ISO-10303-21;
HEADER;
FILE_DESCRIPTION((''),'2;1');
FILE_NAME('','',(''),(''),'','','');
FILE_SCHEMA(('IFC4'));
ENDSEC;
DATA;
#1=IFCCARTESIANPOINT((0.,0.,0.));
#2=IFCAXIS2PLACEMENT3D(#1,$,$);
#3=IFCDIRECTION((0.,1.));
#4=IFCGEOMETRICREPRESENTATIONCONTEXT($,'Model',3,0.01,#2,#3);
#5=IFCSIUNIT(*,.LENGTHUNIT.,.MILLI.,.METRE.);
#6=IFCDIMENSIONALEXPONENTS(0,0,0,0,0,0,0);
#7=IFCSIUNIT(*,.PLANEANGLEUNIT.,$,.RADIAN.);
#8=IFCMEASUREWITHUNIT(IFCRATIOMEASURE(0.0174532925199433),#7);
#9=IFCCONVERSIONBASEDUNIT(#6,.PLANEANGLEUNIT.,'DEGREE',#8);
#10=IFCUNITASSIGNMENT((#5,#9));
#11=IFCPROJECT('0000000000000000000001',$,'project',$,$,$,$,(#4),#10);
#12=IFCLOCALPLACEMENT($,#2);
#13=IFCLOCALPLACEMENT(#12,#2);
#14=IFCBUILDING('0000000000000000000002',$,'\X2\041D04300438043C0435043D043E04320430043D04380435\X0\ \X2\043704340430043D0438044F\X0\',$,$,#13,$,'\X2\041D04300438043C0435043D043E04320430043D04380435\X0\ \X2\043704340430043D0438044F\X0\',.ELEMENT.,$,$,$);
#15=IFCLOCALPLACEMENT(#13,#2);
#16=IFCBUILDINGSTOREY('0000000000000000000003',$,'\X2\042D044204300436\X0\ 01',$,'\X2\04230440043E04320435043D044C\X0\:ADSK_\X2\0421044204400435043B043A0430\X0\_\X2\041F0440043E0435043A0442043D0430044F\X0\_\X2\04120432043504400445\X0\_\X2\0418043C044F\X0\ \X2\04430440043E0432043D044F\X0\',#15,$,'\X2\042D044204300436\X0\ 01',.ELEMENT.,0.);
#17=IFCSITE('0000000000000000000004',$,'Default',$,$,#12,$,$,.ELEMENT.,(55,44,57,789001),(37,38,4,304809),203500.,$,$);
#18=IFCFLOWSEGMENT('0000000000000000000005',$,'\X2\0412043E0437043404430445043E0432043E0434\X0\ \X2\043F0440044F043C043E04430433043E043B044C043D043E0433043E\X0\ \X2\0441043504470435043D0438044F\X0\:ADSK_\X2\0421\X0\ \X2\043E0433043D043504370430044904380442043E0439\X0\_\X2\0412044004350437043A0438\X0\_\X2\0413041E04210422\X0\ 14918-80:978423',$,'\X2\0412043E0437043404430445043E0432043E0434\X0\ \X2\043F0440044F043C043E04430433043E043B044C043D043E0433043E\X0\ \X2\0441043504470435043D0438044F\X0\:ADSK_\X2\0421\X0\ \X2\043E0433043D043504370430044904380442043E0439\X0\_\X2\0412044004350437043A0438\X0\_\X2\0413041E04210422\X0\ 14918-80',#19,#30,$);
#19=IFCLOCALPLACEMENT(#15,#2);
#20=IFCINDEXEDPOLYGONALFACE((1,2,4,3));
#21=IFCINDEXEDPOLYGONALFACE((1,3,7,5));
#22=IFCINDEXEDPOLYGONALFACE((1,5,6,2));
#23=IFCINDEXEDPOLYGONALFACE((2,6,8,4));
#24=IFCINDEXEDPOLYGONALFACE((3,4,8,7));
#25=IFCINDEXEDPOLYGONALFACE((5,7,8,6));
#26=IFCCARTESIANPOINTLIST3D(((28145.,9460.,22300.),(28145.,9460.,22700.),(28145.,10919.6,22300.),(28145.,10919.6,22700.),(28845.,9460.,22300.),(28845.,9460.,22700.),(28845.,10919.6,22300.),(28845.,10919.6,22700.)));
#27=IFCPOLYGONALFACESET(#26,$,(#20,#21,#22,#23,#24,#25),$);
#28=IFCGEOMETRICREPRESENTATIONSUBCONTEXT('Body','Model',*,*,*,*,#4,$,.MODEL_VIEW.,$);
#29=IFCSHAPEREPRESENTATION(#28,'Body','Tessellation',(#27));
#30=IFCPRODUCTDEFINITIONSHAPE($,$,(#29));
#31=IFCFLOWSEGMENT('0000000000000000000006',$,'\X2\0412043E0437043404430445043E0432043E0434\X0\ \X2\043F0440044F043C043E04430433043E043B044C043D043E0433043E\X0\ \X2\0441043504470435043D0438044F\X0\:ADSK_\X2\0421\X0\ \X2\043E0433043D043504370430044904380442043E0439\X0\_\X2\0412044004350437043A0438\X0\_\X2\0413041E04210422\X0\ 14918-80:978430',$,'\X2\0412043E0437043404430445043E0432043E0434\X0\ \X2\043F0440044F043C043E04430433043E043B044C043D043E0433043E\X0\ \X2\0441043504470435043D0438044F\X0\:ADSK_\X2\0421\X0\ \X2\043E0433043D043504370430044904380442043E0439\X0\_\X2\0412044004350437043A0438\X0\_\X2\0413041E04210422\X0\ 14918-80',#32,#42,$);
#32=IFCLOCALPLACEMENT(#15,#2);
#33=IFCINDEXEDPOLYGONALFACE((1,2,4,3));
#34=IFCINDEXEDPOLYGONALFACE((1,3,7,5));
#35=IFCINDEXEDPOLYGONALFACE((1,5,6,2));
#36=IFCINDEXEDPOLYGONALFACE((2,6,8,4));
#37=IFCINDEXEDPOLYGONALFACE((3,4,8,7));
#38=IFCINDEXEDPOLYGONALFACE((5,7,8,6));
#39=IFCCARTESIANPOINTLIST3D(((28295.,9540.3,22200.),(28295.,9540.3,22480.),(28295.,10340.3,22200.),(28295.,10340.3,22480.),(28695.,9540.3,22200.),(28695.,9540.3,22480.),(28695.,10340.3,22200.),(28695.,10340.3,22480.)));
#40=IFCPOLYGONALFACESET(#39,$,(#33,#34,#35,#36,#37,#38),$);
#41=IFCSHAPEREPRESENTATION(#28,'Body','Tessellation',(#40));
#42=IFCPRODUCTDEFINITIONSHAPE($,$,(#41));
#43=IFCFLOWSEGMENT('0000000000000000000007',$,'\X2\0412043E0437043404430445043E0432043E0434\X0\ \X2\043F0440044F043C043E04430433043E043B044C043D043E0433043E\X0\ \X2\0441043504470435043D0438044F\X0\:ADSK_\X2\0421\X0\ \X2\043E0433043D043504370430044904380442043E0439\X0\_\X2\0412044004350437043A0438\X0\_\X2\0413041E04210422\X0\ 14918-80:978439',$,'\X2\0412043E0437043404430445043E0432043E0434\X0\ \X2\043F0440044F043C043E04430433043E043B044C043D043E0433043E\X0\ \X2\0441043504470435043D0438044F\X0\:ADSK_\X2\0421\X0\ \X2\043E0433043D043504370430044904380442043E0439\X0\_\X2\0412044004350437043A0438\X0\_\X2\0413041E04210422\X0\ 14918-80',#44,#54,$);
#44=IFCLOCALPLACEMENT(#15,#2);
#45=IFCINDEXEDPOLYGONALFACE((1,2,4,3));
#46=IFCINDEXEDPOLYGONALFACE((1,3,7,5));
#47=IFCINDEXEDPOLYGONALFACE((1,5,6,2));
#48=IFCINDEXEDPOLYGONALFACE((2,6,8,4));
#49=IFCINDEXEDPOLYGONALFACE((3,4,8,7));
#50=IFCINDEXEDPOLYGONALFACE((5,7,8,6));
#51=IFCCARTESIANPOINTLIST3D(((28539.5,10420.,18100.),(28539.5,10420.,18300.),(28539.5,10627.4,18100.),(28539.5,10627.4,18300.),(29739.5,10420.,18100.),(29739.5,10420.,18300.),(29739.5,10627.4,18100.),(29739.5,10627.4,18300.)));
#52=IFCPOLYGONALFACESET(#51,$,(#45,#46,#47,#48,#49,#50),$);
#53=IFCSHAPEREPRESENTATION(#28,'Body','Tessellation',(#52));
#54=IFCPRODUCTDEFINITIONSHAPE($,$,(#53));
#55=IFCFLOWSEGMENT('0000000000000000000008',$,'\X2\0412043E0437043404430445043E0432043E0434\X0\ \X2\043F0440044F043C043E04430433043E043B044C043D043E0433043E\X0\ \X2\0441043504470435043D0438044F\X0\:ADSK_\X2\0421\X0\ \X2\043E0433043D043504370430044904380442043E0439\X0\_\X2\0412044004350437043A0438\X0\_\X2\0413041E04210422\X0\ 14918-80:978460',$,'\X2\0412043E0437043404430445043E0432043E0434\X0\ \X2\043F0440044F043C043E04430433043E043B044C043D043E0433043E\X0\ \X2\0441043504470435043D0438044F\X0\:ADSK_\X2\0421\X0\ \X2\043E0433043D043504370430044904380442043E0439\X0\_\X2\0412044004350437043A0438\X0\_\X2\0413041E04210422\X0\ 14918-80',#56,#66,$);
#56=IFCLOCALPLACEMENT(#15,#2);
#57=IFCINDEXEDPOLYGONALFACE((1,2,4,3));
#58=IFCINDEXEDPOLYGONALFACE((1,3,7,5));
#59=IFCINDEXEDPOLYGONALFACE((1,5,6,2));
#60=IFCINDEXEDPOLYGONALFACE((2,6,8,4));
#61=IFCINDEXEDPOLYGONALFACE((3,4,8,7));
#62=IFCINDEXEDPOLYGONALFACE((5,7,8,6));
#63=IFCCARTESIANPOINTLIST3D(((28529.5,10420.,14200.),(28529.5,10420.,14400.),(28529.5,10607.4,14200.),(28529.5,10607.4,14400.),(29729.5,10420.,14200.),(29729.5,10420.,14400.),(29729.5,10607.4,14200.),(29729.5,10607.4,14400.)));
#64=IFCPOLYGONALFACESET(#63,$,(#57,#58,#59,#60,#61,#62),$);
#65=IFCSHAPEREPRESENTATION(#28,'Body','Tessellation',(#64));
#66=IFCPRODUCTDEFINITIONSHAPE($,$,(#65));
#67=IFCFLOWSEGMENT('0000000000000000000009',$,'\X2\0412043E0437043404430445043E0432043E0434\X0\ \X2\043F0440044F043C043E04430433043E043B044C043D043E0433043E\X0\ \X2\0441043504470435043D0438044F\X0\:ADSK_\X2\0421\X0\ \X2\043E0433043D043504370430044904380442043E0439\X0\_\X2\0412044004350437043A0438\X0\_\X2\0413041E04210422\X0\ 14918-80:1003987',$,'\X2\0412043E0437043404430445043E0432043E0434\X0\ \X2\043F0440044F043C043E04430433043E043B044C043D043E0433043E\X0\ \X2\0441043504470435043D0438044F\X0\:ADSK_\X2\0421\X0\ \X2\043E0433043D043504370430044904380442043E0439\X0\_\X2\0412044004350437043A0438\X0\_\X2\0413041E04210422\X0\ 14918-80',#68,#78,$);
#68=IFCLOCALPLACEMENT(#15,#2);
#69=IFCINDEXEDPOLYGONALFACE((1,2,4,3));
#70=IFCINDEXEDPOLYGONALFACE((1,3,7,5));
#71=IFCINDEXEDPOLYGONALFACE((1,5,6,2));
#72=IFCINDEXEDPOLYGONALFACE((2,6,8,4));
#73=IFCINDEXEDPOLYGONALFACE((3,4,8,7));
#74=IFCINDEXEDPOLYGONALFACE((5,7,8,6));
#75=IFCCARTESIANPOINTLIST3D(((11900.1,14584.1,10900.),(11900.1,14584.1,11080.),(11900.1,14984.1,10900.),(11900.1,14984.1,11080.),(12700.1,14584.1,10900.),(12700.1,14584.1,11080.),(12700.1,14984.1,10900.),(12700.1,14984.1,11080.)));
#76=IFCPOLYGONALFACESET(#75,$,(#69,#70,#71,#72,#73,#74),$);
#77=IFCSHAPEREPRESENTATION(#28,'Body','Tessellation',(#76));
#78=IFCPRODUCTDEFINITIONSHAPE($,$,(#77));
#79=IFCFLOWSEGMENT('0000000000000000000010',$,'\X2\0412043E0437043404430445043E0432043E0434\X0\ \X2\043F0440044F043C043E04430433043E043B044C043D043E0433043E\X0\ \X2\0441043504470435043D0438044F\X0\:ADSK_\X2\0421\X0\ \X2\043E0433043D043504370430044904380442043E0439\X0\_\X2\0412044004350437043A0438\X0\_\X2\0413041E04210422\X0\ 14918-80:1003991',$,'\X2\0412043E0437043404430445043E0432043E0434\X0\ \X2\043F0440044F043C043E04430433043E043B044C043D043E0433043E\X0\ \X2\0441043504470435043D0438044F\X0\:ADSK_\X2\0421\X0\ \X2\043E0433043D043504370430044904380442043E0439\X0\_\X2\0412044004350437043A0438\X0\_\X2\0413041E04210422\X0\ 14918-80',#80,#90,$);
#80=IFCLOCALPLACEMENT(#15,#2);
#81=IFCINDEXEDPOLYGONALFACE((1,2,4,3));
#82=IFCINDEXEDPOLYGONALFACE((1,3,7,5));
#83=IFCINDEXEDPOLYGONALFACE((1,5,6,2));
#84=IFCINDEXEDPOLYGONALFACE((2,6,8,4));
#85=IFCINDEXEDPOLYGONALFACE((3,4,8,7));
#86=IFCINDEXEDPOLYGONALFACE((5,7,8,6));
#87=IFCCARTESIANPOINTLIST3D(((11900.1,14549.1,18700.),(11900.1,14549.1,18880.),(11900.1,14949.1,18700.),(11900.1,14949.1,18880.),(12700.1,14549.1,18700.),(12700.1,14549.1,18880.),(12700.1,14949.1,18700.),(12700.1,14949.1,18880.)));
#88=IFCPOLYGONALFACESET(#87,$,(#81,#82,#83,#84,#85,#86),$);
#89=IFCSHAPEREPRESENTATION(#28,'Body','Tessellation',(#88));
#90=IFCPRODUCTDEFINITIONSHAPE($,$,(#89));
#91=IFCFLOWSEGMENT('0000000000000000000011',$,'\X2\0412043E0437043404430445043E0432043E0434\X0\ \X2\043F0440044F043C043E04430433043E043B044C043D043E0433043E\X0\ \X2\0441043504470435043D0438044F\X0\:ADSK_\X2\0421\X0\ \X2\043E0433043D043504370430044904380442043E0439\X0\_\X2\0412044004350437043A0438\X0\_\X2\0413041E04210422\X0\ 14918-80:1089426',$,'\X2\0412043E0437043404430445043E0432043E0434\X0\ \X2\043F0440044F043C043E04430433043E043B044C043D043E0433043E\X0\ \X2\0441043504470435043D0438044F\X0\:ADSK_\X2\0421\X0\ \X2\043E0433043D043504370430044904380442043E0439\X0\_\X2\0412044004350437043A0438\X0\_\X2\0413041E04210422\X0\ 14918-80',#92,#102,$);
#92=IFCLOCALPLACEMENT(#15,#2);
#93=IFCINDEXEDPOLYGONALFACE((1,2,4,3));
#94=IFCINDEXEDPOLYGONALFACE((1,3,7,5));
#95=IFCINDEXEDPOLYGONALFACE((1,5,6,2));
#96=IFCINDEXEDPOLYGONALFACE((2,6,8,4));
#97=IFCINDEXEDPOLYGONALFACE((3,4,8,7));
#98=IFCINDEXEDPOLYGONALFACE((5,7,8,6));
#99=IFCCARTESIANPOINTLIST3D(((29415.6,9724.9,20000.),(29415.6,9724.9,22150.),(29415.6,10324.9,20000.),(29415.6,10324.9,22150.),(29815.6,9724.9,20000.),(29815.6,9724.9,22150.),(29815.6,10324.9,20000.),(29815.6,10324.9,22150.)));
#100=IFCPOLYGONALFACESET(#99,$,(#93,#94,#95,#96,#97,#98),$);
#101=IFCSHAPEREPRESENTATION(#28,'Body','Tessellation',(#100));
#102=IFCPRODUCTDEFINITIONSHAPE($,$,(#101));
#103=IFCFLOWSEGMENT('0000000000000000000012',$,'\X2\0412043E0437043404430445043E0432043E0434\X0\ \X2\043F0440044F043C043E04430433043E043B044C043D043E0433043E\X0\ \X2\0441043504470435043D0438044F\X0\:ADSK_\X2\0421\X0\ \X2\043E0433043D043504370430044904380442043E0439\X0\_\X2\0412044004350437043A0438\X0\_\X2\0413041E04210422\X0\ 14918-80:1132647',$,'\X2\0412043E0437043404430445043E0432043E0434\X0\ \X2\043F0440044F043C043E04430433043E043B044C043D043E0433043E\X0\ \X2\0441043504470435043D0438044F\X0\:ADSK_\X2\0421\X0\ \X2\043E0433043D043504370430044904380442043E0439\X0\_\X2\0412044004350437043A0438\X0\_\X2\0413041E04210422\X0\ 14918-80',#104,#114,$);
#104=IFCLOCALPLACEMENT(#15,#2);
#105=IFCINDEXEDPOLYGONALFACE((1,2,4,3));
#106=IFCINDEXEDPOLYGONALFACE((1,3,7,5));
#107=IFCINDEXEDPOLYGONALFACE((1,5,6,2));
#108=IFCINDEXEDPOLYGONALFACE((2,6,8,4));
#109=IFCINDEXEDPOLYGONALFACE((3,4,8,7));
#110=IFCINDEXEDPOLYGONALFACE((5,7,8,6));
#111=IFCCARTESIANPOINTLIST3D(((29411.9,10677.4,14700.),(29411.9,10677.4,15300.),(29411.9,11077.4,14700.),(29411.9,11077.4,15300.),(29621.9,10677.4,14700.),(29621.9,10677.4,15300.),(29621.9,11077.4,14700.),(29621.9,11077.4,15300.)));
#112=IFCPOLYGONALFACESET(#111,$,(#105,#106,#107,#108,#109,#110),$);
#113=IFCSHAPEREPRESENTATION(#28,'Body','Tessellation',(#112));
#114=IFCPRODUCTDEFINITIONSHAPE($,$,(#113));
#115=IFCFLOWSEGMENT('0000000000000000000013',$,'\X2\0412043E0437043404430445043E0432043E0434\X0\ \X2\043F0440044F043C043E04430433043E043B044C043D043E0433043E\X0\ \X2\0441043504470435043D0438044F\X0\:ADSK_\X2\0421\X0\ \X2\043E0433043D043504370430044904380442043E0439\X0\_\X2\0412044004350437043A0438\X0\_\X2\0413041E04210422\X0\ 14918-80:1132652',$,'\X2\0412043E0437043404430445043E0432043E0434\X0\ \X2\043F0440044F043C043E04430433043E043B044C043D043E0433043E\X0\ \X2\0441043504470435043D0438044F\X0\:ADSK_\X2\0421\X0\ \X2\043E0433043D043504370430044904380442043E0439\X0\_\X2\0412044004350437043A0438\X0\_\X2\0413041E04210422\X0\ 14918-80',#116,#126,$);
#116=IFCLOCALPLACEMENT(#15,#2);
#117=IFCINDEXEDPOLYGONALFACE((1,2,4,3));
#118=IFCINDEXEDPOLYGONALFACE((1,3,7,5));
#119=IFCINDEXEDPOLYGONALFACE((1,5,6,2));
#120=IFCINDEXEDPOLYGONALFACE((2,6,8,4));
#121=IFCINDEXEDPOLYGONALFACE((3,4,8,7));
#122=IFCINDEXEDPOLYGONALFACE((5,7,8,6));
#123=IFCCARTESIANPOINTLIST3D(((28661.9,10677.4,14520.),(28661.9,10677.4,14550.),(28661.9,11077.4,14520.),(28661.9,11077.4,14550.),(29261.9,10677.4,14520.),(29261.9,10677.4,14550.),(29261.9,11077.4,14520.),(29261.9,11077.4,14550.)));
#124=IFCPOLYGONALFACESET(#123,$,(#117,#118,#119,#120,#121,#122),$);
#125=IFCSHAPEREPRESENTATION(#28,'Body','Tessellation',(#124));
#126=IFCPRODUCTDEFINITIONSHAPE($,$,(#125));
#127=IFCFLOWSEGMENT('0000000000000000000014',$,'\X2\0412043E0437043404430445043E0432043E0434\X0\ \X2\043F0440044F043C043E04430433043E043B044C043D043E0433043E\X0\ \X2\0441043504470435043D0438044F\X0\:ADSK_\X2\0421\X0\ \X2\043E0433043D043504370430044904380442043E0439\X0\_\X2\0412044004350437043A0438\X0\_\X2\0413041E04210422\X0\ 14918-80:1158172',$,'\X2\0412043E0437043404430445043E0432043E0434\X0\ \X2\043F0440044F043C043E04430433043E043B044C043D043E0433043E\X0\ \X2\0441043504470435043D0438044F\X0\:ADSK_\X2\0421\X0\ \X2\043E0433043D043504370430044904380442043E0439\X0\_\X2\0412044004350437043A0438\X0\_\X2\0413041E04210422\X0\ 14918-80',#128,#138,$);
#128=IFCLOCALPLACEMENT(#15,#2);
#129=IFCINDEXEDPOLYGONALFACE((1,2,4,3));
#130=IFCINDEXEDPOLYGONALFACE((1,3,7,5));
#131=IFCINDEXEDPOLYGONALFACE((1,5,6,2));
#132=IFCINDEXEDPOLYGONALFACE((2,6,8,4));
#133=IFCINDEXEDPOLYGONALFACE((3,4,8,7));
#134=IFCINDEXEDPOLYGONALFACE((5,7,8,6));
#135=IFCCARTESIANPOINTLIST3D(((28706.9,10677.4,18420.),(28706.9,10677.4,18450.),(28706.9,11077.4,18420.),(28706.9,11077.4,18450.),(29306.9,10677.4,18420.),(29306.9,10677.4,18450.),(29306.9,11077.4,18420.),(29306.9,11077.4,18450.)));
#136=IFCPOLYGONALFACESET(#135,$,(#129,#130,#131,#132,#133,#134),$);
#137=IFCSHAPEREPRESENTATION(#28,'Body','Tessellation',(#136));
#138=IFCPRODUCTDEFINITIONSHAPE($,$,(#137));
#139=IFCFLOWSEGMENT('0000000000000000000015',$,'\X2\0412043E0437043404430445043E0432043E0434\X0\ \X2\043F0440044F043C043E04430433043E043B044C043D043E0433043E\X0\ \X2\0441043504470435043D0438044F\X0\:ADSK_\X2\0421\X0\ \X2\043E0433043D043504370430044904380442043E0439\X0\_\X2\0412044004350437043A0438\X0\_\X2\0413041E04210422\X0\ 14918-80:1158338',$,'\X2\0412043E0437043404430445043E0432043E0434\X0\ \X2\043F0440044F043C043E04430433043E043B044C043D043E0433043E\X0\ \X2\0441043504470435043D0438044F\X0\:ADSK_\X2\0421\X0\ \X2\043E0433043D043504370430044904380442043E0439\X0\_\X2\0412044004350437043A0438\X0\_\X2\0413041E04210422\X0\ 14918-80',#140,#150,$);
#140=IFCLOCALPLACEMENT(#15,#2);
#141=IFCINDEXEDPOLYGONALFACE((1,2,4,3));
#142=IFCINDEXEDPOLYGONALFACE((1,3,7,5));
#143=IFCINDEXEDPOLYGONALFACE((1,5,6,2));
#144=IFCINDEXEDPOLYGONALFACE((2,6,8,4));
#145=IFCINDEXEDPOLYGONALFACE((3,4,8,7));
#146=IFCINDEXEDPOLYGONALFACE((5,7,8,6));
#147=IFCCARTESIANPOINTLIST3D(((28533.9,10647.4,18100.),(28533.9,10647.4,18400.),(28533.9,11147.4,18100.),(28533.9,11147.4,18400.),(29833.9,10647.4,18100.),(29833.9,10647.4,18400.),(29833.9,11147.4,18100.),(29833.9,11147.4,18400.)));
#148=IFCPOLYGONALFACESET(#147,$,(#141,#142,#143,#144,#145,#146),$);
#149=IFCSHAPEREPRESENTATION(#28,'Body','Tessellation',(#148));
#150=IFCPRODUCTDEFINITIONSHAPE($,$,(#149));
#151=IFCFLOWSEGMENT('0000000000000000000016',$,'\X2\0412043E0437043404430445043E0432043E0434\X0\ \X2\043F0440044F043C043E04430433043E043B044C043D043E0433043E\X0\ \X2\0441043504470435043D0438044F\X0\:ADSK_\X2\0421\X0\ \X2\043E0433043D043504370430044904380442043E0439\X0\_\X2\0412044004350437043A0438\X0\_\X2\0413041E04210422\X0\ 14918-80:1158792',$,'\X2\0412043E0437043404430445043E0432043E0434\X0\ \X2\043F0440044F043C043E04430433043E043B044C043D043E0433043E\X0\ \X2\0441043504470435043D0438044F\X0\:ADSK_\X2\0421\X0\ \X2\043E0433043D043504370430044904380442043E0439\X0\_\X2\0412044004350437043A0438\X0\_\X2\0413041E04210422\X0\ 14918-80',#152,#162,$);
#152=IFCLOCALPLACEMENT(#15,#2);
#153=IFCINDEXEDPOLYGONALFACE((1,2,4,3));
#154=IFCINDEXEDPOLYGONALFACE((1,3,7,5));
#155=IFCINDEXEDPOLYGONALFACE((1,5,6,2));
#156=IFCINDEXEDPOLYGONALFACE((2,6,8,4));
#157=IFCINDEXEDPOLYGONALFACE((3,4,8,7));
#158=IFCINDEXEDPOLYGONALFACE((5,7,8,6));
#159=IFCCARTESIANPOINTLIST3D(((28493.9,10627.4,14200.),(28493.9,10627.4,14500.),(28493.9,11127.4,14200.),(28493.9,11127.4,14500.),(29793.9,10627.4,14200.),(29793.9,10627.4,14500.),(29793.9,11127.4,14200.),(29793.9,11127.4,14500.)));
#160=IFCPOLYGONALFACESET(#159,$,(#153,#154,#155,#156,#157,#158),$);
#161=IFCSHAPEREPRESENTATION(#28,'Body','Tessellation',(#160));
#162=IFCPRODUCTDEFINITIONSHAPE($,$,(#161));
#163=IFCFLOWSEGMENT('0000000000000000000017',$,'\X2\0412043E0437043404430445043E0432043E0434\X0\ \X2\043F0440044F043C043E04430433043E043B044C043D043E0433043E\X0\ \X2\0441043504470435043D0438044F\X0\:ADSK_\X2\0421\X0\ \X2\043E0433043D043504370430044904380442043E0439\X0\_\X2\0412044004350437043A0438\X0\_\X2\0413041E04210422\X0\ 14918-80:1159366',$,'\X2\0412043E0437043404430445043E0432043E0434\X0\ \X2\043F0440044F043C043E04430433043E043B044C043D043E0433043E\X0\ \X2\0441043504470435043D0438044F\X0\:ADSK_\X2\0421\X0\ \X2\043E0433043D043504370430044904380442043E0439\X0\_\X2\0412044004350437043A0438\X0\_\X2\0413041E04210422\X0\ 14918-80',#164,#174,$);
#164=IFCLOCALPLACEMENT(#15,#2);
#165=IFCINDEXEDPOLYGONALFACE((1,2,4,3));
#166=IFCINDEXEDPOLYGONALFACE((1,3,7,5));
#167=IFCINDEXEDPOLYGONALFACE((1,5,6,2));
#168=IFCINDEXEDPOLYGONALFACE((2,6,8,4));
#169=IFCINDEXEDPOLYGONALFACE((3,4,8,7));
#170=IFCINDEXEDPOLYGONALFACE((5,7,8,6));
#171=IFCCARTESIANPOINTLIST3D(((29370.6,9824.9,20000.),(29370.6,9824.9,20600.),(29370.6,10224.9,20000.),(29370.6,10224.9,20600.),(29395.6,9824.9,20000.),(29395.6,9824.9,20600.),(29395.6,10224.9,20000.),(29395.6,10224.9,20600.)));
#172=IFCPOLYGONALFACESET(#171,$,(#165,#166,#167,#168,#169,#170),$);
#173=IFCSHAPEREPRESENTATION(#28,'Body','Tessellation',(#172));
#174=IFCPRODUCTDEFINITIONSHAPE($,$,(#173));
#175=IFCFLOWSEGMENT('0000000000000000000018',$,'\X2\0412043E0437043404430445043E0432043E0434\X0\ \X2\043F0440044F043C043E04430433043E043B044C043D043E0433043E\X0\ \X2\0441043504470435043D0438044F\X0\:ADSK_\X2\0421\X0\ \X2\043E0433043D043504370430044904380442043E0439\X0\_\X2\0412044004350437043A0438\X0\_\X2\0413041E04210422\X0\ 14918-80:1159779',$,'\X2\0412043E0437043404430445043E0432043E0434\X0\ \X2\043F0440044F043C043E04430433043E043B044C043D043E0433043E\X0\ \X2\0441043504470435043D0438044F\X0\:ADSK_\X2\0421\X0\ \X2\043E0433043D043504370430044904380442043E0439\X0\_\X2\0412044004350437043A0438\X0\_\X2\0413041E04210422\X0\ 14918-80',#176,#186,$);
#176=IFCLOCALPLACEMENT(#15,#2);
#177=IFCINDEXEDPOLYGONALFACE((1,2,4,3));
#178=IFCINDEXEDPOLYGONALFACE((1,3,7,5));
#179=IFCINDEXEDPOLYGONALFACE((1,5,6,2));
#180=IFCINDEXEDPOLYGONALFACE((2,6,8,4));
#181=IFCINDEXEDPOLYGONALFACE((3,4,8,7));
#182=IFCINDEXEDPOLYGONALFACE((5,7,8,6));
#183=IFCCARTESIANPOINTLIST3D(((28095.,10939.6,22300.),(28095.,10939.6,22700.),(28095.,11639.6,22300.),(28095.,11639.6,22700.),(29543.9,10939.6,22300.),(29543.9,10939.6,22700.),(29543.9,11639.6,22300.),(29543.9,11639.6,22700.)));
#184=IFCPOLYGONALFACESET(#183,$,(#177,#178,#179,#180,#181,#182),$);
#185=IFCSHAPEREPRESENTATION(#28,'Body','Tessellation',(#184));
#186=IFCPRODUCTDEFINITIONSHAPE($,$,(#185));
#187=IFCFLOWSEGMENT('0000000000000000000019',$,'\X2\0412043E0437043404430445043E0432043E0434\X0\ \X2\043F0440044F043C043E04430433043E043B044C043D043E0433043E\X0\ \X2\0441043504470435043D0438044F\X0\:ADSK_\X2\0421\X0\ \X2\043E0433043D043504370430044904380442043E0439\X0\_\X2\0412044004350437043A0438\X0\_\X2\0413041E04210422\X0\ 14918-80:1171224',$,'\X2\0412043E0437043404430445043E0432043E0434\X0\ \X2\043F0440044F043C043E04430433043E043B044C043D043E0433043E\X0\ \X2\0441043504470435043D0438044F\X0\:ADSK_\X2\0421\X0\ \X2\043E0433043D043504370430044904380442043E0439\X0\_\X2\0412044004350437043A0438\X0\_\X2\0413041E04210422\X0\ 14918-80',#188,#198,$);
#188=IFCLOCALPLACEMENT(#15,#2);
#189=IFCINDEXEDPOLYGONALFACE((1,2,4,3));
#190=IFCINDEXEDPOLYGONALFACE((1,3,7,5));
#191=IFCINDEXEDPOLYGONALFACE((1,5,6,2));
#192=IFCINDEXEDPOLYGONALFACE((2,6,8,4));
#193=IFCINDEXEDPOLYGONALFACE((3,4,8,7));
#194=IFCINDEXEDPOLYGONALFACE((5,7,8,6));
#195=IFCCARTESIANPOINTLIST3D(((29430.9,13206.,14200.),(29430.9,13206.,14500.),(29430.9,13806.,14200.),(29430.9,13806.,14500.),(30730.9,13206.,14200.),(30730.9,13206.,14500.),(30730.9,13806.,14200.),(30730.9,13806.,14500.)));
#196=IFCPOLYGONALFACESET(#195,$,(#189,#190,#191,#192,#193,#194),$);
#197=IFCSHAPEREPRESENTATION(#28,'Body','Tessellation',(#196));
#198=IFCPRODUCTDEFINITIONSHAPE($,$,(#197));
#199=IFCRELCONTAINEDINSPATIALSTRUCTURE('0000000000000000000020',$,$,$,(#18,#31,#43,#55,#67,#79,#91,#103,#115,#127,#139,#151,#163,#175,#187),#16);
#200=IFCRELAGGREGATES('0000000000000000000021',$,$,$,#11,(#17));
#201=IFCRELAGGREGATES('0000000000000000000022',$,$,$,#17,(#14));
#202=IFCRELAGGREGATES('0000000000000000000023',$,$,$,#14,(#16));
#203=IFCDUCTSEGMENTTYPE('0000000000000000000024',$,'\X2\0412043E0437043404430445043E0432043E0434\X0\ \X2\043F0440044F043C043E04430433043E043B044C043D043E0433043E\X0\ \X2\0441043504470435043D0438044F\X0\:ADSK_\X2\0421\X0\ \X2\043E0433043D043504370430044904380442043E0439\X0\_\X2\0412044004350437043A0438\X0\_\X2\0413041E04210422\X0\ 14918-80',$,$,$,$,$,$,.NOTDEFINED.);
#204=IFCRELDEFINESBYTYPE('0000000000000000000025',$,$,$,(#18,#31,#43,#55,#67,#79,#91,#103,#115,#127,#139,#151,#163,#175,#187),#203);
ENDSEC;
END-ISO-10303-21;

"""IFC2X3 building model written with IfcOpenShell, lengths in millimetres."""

from ifc_helpers import new_model, entity, si_unit, converted_unit, direction, frame, origin, origin_2d_with_axis, place, context, subcontext, project, spatial, rectangle, extrude, type_object, element, save


model = new_model("IFC2X3")

# Units and contexts
model_context = context("Model", 3, precision=0.01, world=origin(), true_north=direction((0.0, 1.0)))
body_context = subcontext(model_context, "Body", "Model", "MODEL_VIEW")
ifc_project = project(units=[si_unit("LENGTHUNIT", "METRE", prefix="MILLI"), converted_unit("PLANEANGLEUNIT", "DEGREE", entity("IfcRatioMeasure", 0.0174532925199433), si_unit("PLANEANGLEUNIT", "RADIAN"), dimensions=[0, 0, 0, 0, 0, 0, 0])], contexts=[model_context])

# Site, building, storey
site_placement = place(None, origin())
site = spatial("IfcSite", under=ifc_project, at=site_placement, Name="Default", CompositionType="ELEMENT", RefLatitude=(55, 44, 57, 789001), RefLongitude=(37, 38, 4, 304809), RefElevation=203500.0)
building_placement = place(site_placement, origin())
building = spatial("IfcBuilding", under=site, at=building_placement, Name="Наименование здания", LongName="Наименование здания", CompositionType="ELEMENT")
storey_placement = place(building_placement, origin())
storey = spatial("IfcBuildingStorey", under=building, at=storey_placement, Name="Этаж 01", ObjectType="Уровень:ADSK_Стрелка_Проектная_Вверх_Имя уровня", LongName="Этаж 01", CompositionType="ELEMENT", Elevation=0.0)

# Flow segments
duct_segment_type = type_object("IfcDuctSegmentType", Name="Воздуховод прямоугольного сечения:ADSK_С огнезащитой_Врезки_ГОСТ 14918-80", PredefinedType="NOTDEFINED")
flow_segment_1_placement = place(storey_placement, frame((28145.0, 9460.0, 22300.0)))
element("IfcFlowSegment", 1, at=flow_segment_1_placement, inside=storey, type_object=duct_segment_type, Name="Воздуховод прямоугольного сечения:ADSK_С огнезащитой_Врезки_ГОСТ 14918-80:978423", ObjectType="Воздуховод прямоугольного сечения:ADSK_С огнезащитой_Врезки_ГОСТ 14918-80", context=body_context, shape_type="SweptSolid", body=[
    extrude(rectangle(XDim=1459.6, YDim=700.0, at=origin_2d_with_axis()), frame((350.0, 729.8, 0.0), z_axis=(0.0, 0.0, 1.0), x_axis=(0.0, 1.0, 0.0)), (0.0, 0.0, 1.0), 400.0),
])
flow_segment_2_placement = place(storey_placement, frame((28295.0, 9540.3, 22200.0)))
element("IfcFlowSegment", 2, at=flow_segment_2_placement, inside=storey, type_object=duct_segment_type, Name="Воздуховод прямоугольного сечения:ADSK_С огнезащитой_Врезки_ГОСТ 14918-80:978430", ObjectType="Воздуховод прямоугольного сечения:ADSK_С огнезащитой_Врезки_ГОСТ 14918-80", context=body_context, shape_type="SweptSolid", body=[
    extrude(rectangle(XDim=800.0, YDim=400.0, at=origin_2d_with_axis()), frame((200.0, 400.0, 0.0), z_axis=(0.0, 0.0, 1.0), x_axis=(0.0, 1.0, 0.0)), (0.0, 0.0, 1.0), 280.0),
])
flow_segment_3_placement = place(storey_placement, frame((28539.5, 10420.0, 18100.0)))
element("IfcFlowSegment", 3, at=flow_segment_3_placement, inside=storey, type_object=duct_segment_type, Name="Воздуховод прямоугольного сечения:ADSK_С огнезащитой_Врезки_ГОСТ 14918-80:978439", ObjectType="Воздуховод прямоугольного сечения:ADSK_С огнезащитой_Врезки_ГОСТ 14918-80", context=body_context, shape_type="SweptSolid", body=[
    extrude(rectangle(XDim=207.4, YDim=1200.0, at=origin_2d_with_axis()), frame((600.0, 103.7, 0.0), z_axis=(0.0, 0.0, 1.0), x_axis=(0.0, 1.0, 0.0)), (0.0, 0.0, 1.0), 200.0),
])
flow_segment_4_placement = place(storey_placement, frame((28529.5, 10420.0, 14200.0)))
element("IfcFlowSegment", 4, at=flow_segment_4_placement, inside=storey, type_object=duct_segment_type, Name="Воздуховод прямоугольного сечения:ADSK_С огнезащитой_Врезки_ГОСТ 14918-80:978460", ObjectType="Воздуховод прямоугольного сечения:ADSK_С огнезащитой_Врезки_ГОСТ 14918-80", context=body_context, shape_type="SweptSolid", body=[
    extrude(rectangle(XDim=187.4, YDim=1200.0, at=origin_2d_with_axis()), frame((600.0, 93.7, 0.0), z_axis=(0.0, 0.0, 1.0), x_axis=(0.0, 1.0, 0.0)), (0.0, 0.0, 1.0), 200.0),
])
flow_segment_5_placement = place(storey_placement, frame((11900.1, 14584.1, 10900.0)))
element("IfcFlowSegment", 5, at=flow_segment_5_placement, inside=storey, type_object=duct_segment_type, Name="Воздуховод прямоугольного сечения:ADSK_С огнезащитой_Врезки_ГОСТ 14918-80:1003987", ObjectType="Воздуховод прямоугольного сечения:ADSK_С огнезащитой_Врезки_ГОСТ 14918-80", context=body_context, shape_type="SweptSolid", body=[
    extrude(rectangle(XDim=400.0, YDim=800.0, at=origin_2d_with_axis()), frame((400.0, 200.0, 0.0), z_axis=(0.0, 0.0, 1.0), x_axis=(0.0, 1.0, 0.0)), (0.0, 0.0, 1.0), 180.0),
])
flow_segment_6_placement = place(storey_placement, frame((11900.1, 14549.1, 18700.0)))
element("IfcFlowSegment", 6, at=flow_segment_6_placement, inside=storey, type_object=duct_segment_type, Name="Воздуховод прямоугольного сечения:ADSK_С огнезащитой_Врезки_ГОСТ 14918-80:1003991", ObjectType="Воздуховод прямоугольного сечения:ADSK_С огнезащитой_Врезки_ГОСТ 14918-80", context=body_context, shape_type="SweptSolid", body=[
    extrude(rectangle(XDim=800.0, YDim=400.0, at=origin_2d_with_axis()), frame((400.0, 200.0, 0.0)), (0.0, 0.0, 1.0), 180.0),
])
flow_segment_7_placement = place(storey_placement, frame((29415.6, 9724.9, 20000.0)))
element("IfcFlowSegment", 7, at=flow_segment_7_placement, inside=storey, type_object=duct_segment_type, Name="Воздуховод прямоугольного сечения:ADSK_С огнезащитой_Врезки_ГОСТ 14918-80:1089426", ObjectType="Воздуховод прямоугольного сечения:ADSK_С огнезащитой_Врезки_ГОСТ 14918-80", context=body_context, shape_type="SweptSolid", body=[
    extrude(rectangle(XDim=600.0, YDim=400.0, at=origin_2d_with_axis()), frame((200.0, 300.0, 0.0), z_axis=(0.0, 0.0, 1.0), x_axis=(0.0, 1.0, 0.0)), (0.0, 0.0, 1.0), 2150.0),
])
flow_segment_8_placement = place(storey_placement, frame((29411.9, 10677.4, 14700.0)))
element("IfcFlowSegment", 8, at=flow_segment_8_placement, inside=storey, type_object=duct_segment_type, Name="Воздуховод прямоугольного сечения:ADSK_С огнезащитой_Врезки_ГОСТ 14918-80:1132647", ObjectType="Воздуховод прямоугольного сечения:ADSK_С огнезащитой_Врезки_ГОСТ 14918-80", context=body_context, shape_type="SweptSolid", body=[
    extrude(rectangle(XDim=210.0, YDim=400.0, at=origin_2d_with_axis()), frame((105.0, 200.0, 0.0), z_axis=(0.0, 0.0, 1.0), x_axis=(-1.0, 0.0, 0.0)), (0.0, 0.0, 1.0), 600.0),
])
flow_segment_9_placement = place(storey_placement, frame((28661.9, 10677.4, 14520.0)))
element("IfcFlowSegment", 9, at=flow_segment_9_placement, inside=storey, type_object=duct_segment_type, Name="Воздуховод прямоугольного сечения:ADSK_С огнезащитой_Врезки_ГОСТ 14918-80:1132652", ObjectType="Воздуховод прямоугольного сечения:ADSK_С огнезащитой_Врезки_ГОСТ 14918-80", context=body_context, shape_type="SweptSolid", body=[
    extrude(rectangle(XDim=400.0, YDim=600.0, at=origin_2d_with_axis()), frame((300.0, 200.0, 0.0), z_axis=(0.0, 0.0, 1.0), x_axis=(0.0, 1.0, 0.0)), (0.0, 0.0, 1.0), 30.0),
])
flow_segment_10_placement = place(storey_placement, frame((28706.9, 10677.4, 18420.0)))
element("IfcFlowSegment", 10, at=flow_segment_10_placement, inside=storey, type_object=duct_segment_type, Name="Воздуховод прямоугольного сечения:ADSK_С огнезащитой_Врезки_ГОСТ 14918-80:1158172", ObjectType="Воздуховод прямоугольного сечения:ADSK_С огнезащитой_Врезки_ГОСТ 14918-80", context=body_context, shape_type="SweptSolid", body=[
    extrude(rectangle(XDim=400.0, YDim=600.0, at=origin_2d_with_axis()), frame((300.0, 200.0, 0.0), z_axis=(0.0, 0.0, 1.0), x_axis=(0.0, 1.0, 0.0)), (0.0, 0.0, 1.0), 30.0),
])
for number, where, name in (
    (11, (28533.9, 10647.4, 18100.0), "Воздуховод прямоугольного сечения:ADSK_С огнезащитой_Врезки_ГОСТ 14918-80:1158338"),
    (12, (28493.9, 10627.4, 14200.0), "Воздуховод прямоугольного сечения:ADSK_С огнезащитой_Врезки_ГОСТ 14918-80:1158792"),
):
    element("IfcFlowSegment", number, at=place(storey_placement, frame(where)), inside=storey, type_object=duct_segment_type, Name=name, ObjectType="Воздуховод прямоугольного сечения:ADSK_С огнезащитой_Врезки_ГОСТ 14918-80", context=body_context, shape_type="SweptSolid", body=[
        extrude(rectangle(XDim=1300.0, YDim=500.0, at=origin_2d_with_axis()), frame((650.0, 250.0, 0.0), z_axis=(0.0, 0.0, 1.0), x_axis=(-1.0, 0.0, 0.0)), (0.0, 0.0, 1.0), 300.0),
    ])
flow_segment_11_placement = place(storey_placement, frame((29370.6, 9824.9, 20000.0)))
element("IfcFlowSegment", 13, at=flow_segment_11_placement, inside=storey, type_object=duct_segment_type, Name="Воздуховод прямоугольного сечения:ADSK_С огнезащитой_Врезки_ГОСТ 14918-80:1159366", ObjectType="Воздуховод прямоугольного сечения:ADSK_С огнезащитой_Врезки_ГОСТ 14918-80", context=body_context, shape_type="SweptSolid", body=[
    extrude(rectangle(XDim=25.0, YDim=400.0, at=origin_2d_with_axis()), frame((12.5, 200.0, 0.0), z_axis=(0.0, 0.0, 1.0), x_axis=(-1.0, 0.0, 0.0)), (0.0, 0.0, 1.0), 600.0),
])
flow_segment_12_placement = place(storey_placement, frame((28095.0, 10939.6, 22300.0)))
element("IfcFlowSegment", 14, at=flow_segment_12_placement, inside=storey, type_object=duct_segment_type, Name="Воздуховод прямоугольного сечения:ADSK_С огнезащитой_Врезки_ГОСТ 14918-80:1159779", ObjectType="Воздуховод прямоугольного сечения:ADSK_С огнезащитой_Врезки_ГОСТ 14918-80", context=body_context, shape_type="SweptSolid", body=[
    extrude(rectangle(XDim=1448.9, YDim=700.0, at=origin_2d_with_axis()), frame((724.5, 350.0, 0.0), z_axis=(0.0, 0.0, 1.0), x_axis=(-1.0, 0.0, 0.0)), (0.0, 0.0, 1.0), 400.0),
])
for number, where, name in (
    (15, (29430.9, 13206.0, 14200.0), "Воздуховод прямоугольного сечения:ADSK_С огнезащитой_Врезки_ГОСТ 14918-80:1171224"),
):
    element("IfcFlowSegment", number, at=place(storey_placement, frame(where)), inside=storey, type_object=duct_segment_type, Name=name, ObjectType="Воздуховод прямоугольного сечения:ADSK_С огнезащитой_Врезки_ГОСТ 14918-80", context=body_context, shape_type="SweptSolid", body=[
        extrude(rectangle(XDim=1300.0, YDim=600.0, at=origin_2d_with_axis()), frame((650.0, 300.0, 0.0), z_axis=(0.0, 0.0, 1.0), x_axis=(-1.0, 0.0, 0.0)), (0.0, 0.0, 1.0), 300.0),
    ])

save(model, "model.ifc")
